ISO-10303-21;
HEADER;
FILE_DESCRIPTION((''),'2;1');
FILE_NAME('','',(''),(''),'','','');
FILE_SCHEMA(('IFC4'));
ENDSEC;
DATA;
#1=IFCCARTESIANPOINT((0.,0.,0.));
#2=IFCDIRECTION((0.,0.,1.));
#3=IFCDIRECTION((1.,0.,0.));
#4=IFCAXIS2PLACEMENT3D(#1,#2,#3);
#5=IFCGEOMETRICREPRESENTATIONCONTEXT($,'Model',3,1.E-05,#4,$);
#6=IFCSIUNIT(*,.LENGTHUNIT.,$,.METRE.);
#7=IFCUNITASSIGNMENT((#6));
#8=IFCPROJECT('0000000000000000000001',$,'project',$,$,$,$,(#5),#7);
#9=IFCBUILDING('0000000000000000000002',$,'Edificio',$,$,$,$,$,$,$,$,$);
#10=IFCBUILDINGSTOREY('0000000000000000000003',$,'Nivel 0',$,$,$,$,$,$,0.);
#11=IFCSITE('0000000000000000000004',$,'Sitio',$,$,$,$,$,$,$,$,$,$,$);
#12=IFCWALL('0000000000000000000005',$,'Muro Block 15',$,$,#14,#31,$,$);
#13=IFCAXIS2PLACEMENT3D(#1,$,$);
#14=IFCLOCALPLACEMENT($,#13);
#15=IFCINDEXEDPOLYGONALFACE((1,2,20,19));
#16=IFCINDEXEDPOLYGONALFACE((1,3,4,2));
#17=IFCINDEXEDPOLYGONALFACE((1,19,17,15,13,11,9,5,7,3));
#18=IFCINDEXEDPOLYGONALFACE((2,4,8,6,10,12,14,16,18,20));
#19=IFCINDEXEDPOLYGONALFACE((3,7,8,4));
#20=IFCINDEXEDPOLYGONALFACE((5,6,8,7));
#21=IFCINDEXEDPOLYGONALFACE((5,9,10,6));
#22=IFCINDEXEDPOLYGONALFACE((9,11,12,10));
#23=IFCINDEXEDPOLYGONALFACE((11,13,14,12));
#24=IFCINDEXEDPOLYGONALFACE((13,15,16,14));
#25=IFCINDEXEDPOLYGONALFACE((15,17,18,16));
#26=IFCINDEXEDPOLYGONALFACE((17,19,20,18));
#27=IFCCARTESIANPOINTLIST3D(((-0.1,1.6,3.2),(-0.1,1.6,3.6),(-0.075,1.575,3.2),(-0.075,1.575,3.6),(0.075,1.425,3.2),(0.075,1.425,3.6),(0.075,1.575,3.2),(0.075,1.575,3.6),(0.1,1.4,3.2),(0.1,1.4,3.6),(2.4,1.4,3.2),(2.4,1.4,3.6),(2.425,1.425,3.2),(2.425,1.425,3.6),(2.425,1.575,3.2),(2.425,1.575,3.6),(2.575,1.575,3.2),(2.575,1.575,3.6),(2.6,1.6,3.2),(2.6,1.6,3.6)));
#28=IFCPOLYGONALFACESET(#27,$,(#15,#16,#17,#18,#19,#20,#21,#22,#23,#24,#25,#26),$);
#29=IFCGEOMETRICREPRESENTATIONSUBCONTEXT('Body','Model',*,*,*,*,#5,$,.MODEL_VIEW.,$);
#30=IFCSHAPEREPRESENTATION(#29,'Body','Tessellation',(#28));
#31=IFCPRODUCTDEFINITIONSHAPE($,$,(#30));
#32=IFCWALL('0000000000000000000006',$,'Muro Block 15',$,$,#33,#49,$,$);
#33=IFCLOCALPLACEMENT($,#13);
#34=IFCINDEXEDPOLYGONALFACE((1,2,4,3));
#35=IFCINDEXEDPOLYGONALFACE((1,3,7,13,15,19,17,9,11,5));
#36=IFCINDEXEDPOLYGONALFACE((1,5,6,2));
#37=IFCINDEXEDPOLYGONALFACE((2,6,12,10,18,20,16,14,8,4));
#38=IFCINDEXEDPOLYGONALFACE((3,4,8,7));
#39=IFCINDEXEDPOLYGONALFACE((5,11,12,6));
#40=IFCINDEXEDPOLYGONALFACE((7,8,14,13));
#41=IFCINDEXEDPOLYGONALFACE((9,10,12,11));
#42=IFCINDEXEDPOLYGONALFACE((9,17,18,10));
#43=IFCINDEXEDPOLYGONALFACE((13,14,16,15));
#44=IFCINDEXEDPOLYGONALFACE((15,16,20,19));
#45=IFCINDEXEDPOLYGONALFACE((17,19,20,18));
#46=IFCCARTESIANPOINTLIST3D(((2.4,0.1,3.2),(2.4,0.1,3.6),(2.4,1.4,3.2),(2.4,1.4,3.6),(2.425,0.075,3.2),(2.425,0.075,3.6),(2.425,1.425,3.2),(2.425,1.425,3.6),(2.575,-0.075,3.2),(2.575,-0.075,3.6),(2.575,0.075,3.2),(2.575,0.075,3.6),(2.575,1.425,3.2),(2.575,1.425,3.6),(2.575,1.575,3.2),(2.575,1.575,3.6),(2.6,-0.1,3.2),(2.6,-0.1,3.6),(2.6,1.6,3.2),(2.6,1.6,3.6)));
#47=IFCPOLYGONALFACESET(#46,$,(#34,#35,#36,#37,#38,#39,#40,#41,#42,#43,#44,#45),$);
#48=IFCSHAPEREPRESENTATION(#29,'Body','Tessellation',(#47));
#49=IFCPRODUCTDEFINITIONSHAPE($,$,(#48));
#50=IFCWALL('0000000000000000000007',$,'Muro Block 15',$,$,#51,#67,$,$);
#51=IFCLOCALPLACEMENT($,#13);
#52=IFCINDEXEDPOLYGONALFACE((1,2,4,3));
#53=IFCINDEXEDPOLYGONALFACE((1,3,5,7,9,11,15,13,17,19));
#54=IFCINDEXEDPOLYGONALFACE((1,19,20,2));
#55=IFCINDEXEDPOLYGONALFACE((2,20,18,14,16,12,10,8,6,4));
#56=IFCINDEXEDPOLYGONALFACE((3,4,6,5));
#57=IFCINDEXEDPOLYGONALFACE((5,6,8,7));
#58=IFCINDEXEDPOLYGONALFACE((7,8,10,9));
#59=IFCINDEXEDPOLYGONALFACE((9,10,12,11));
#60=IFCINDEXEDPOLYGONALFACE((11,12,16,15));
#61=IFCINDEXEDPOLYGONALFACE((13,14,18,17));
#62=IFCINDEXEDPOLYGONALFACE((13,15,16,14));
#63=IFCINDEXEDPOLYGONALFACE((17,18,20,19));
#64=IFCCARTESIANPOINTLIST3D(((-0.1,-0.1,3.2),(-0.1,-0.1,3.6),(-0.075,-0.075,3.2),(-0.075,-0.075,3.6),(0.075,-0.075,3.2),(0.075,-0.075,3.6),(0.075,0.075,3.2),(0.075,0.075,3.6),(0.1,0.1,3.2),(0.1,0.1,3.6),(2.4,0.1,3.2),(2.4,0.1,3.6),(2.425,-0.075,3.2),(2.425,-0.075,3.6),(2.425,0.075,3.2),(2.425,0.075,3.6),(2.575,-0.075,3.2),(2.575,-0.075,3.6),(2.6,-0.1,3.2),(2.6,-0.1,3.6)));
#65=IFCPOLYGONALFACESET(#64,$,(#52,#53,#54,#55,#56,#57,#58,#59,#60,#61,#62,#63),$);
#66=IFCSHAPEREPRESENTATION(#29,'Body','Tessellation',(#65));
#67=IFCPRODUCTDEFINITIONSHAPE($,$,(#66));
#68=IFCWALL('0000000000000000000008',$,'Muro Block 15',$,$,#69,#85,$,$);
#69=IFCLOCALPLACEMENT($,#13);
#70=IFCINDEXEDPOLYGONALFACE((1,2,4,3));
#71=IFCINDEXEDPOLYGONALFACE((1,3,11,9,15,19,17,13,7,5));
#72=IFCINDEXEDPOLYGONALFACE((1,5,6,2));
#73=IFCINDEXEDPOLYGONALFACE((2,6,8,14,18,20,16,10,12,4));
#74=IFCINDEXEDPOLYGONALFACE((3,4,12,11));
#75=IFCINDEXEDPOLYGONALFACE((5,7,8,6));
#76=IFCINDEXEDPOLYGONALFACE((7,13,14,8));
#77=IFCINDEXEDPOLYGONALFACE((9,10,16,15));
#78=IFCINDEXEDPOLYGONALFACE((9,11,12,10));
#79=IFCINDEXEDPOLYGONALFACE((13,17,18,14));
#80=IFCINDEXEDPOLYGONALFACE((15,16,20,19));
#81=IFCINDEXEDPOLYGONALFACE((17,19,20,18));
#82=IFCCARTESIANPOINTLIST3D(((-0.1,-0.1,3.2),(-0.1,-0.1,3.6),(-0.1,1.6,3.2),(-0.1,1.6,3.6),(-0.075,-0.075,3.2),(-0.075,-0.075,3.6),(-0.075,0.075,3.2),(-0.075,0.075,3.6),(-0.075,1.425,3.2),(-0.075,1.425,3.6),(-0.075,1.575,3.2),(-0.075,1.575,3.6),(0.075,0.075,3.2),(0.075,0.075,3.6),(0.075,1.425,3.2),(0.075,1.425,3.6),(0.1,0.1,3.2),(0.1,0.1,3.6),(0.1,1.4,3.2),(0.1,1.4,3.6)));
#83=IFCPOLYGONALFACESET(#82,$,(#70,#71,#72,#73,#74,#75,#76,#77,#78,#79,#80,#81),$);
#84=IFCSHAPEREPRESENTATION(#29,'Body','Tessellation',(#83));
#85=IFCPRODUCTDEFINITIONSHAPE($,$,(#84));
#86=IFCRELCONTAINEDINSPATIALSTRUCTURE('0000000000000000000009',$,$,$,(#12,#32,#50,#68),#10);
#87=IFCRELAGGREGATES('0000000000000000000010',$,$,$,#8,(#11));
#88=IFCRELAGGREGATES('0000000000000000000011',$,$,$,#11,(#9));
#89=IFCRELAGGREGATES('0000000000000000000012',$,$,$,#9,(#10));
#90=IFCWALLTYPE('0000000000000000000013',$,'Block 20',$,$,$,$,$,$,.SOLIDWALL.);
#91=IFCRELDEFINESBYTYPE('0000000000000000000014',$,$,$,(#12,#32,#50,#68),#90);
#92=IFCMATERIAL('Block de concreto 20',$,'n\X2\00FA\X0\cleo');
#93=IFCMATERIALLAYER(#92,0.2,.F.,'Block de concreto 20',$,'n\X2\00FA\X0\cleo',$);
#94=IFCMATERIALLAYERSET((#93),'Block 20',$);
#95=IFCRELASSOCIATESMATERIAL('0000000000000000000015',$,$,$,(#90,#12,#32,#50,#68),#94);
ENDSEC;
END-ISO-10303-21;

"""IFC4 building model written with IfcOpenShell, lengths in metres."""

from ifc_helpers import new_model, si_unit, frame, origin_with_axes, place, context, subcontext, project, spatial, indexed_curve, outline, extrude, material, layer, layer_set, layer_usage, type_object, element, save


model = new_model("IFC4")

# Units and contexts
model_context = context("Model", 3, precision=1e-05, world=origin_with_axes())
body_context = subcontext(model_context, "Body", "Model", "MODEL_VIEW")
ifc_project = project(units=[si_unit("LENGTHUNIT", "METRE")], contexts=[model_context])

# Site, building, storey
site = spatial("IfcSite", under=ifc_project, Name="Sitio")
building = spatial("IfcBuilding", under=site, Name="Edificio")
storey = spatial("IfcBuildingStorey", under=building, Name="Nivel 0", Elevation=0.0)

# Walls
ifc_material = material(Name="Block de concreto 20", Category="núcleo")
ifc_layer = layer(ifc_material, 0.2, ventilated=False, Name="Block de concreto 20", Category="núcleo")
ifc_layer_set = layer_set([ifc_layer], Name="Block 20")
ifc_layer_usage_1 = layer_usage(ifc_layer_set, "AXIS2", "POSITIVE", 0.0)
wall_type = type_object("IfcWallType", Name="Block 20", PredefinedType="SOLIDWALL", material=ifc_layer_set)
wall_1_placement = place(None, frame((0.0, 1.5, 0.0), z_axis=(0.0, 0.0, 1.0), x_axis=(1.0, 0.0, 0.0)))
element("IfcWall", 1, at=wall_1_placement, inside=storey, type_object=wall_type, material=ifc_layer_usage_1, Name="Muro Block 15", context=body_context, shape_type="SweptSolid", body=[
    extrude(outline(indexed_curve([(2.6, 0.1), (2.575, 0.075), (2.425, 0.075), (2.425, -0.075), (2.4, -0.1), (0.1, -0.1), (0.075, -0.075), (0.075, 0.075), (-0.075, 0.075), (-0.1, 0.1)])), frame((0.0, 0.0, 3.2), z_axis=(0.0, 0.0, 1.0), x_axis=(1.0, 0.0, 0.0)), (0.0, 0.0, 1.0), 0.4),
])
ifc_layer_usage_2 = layer_usage(ifc_layer_set, "AXIS2", "POSITIVE", 0.0)
wall_2_placement = place(None, frame((2.5, 1.5, 0.0), z_axis=(0.0, 0.0, 1.0), x_axis=(0.0, -1.0, 0.0)))
element("IfcWall", 2, at=wall_2_placement, inside=storey, type_object=wall_type, material=ifc_layer_usage_2, Name="Muro Block 15", context=body_context, shape_type="SweptSolid", body=[
    extrude(outline(indexed_curve([(1.6, 0.1), (1.575, 0.075), (1.425, 0.075), (1.425, -0.075), (1.4, -0.1), (0.1, -0.1), (0.075, -0.075), (0.075, 0.075), (-0.075, 0.075), (-0.1, 0.1)])), frame((0.0, 0.0, 3.2), z_axis=(0.0, 0.0, 1.0), x_axis=(1.0, 0.0, 0.0)), (0.0, 0.0, 1.0), 0.4),
])
ifc_layer_usage_3 = layer_usage(ifc_layer_set, "AXIS2", "POSITIVE", 0.0)
wall_3_placement = place(None, frame((2.5, 0.0, 0.0), z_axis=(0.0, 0.0, 1.0), x_axis=(-1.0, 0.0, 0.0)))
element("IfcWall", 3, at=wall_3_placement, inside=storey, type_object=wall_type, material=ifc_layer_usage_3, Name="Muro Block 15", context=body_context, shape_type="SweptSolid", body=[
    extrude(outline(indexed_curve([(2.6, 0.1), (2.575, 0.075), (2.425, 0.075), (2.425, -0.075), (2.4, -0.1), (0.1, -0.1), (0.075, -0.075), (0.075, 0.075), (-0.075, 0.075), (-0.1, 0.1)])), frame((0.0, 0.0, 3.2), z_axis=(0.0, 0.0, 1.0), x_axis=(1.0, 0.0, 0.0)), (0.0, 0.0, 1.0), 0.4),
])
ifc_layer_usage_4 = layer_usage(ifc_layer_set, "AXIS2", "POSITIVE", 0.0)
wall_4_placement = place(None, frame((0.0, 0.0, 0.0), z_axis=(0.0, 0.0, 1.0), x_axis=(0.0, 1.0, 0.0)))
element("IfcWall", 4, at=wall_4_placement, inside=storey, type_object=wall_type, material=ifc_layer_usage_4, Name="Muro Block 15", context=body_context, shape_type="SweptSolid", body=[
    extrude(outline(indexed_curve([(0.1, -0.1), (0.075, -0.075), (0.075, 0.075), (-0.075, 0.075), (-0.1, 0.1), (1.6, 0.1), (1.575, 0.075), (1.425, 0.075), (1.425, -0.075), (1.4, -0.1)])), frame((0.0, 0.0, 3.2), z_axis=(0.0, 0.0, 1.0), x_axis=(1.0, 0.0, 0.0)), (0.0, 0.0, 1.0), 0.4),
])

save(model, "model.ifc")
